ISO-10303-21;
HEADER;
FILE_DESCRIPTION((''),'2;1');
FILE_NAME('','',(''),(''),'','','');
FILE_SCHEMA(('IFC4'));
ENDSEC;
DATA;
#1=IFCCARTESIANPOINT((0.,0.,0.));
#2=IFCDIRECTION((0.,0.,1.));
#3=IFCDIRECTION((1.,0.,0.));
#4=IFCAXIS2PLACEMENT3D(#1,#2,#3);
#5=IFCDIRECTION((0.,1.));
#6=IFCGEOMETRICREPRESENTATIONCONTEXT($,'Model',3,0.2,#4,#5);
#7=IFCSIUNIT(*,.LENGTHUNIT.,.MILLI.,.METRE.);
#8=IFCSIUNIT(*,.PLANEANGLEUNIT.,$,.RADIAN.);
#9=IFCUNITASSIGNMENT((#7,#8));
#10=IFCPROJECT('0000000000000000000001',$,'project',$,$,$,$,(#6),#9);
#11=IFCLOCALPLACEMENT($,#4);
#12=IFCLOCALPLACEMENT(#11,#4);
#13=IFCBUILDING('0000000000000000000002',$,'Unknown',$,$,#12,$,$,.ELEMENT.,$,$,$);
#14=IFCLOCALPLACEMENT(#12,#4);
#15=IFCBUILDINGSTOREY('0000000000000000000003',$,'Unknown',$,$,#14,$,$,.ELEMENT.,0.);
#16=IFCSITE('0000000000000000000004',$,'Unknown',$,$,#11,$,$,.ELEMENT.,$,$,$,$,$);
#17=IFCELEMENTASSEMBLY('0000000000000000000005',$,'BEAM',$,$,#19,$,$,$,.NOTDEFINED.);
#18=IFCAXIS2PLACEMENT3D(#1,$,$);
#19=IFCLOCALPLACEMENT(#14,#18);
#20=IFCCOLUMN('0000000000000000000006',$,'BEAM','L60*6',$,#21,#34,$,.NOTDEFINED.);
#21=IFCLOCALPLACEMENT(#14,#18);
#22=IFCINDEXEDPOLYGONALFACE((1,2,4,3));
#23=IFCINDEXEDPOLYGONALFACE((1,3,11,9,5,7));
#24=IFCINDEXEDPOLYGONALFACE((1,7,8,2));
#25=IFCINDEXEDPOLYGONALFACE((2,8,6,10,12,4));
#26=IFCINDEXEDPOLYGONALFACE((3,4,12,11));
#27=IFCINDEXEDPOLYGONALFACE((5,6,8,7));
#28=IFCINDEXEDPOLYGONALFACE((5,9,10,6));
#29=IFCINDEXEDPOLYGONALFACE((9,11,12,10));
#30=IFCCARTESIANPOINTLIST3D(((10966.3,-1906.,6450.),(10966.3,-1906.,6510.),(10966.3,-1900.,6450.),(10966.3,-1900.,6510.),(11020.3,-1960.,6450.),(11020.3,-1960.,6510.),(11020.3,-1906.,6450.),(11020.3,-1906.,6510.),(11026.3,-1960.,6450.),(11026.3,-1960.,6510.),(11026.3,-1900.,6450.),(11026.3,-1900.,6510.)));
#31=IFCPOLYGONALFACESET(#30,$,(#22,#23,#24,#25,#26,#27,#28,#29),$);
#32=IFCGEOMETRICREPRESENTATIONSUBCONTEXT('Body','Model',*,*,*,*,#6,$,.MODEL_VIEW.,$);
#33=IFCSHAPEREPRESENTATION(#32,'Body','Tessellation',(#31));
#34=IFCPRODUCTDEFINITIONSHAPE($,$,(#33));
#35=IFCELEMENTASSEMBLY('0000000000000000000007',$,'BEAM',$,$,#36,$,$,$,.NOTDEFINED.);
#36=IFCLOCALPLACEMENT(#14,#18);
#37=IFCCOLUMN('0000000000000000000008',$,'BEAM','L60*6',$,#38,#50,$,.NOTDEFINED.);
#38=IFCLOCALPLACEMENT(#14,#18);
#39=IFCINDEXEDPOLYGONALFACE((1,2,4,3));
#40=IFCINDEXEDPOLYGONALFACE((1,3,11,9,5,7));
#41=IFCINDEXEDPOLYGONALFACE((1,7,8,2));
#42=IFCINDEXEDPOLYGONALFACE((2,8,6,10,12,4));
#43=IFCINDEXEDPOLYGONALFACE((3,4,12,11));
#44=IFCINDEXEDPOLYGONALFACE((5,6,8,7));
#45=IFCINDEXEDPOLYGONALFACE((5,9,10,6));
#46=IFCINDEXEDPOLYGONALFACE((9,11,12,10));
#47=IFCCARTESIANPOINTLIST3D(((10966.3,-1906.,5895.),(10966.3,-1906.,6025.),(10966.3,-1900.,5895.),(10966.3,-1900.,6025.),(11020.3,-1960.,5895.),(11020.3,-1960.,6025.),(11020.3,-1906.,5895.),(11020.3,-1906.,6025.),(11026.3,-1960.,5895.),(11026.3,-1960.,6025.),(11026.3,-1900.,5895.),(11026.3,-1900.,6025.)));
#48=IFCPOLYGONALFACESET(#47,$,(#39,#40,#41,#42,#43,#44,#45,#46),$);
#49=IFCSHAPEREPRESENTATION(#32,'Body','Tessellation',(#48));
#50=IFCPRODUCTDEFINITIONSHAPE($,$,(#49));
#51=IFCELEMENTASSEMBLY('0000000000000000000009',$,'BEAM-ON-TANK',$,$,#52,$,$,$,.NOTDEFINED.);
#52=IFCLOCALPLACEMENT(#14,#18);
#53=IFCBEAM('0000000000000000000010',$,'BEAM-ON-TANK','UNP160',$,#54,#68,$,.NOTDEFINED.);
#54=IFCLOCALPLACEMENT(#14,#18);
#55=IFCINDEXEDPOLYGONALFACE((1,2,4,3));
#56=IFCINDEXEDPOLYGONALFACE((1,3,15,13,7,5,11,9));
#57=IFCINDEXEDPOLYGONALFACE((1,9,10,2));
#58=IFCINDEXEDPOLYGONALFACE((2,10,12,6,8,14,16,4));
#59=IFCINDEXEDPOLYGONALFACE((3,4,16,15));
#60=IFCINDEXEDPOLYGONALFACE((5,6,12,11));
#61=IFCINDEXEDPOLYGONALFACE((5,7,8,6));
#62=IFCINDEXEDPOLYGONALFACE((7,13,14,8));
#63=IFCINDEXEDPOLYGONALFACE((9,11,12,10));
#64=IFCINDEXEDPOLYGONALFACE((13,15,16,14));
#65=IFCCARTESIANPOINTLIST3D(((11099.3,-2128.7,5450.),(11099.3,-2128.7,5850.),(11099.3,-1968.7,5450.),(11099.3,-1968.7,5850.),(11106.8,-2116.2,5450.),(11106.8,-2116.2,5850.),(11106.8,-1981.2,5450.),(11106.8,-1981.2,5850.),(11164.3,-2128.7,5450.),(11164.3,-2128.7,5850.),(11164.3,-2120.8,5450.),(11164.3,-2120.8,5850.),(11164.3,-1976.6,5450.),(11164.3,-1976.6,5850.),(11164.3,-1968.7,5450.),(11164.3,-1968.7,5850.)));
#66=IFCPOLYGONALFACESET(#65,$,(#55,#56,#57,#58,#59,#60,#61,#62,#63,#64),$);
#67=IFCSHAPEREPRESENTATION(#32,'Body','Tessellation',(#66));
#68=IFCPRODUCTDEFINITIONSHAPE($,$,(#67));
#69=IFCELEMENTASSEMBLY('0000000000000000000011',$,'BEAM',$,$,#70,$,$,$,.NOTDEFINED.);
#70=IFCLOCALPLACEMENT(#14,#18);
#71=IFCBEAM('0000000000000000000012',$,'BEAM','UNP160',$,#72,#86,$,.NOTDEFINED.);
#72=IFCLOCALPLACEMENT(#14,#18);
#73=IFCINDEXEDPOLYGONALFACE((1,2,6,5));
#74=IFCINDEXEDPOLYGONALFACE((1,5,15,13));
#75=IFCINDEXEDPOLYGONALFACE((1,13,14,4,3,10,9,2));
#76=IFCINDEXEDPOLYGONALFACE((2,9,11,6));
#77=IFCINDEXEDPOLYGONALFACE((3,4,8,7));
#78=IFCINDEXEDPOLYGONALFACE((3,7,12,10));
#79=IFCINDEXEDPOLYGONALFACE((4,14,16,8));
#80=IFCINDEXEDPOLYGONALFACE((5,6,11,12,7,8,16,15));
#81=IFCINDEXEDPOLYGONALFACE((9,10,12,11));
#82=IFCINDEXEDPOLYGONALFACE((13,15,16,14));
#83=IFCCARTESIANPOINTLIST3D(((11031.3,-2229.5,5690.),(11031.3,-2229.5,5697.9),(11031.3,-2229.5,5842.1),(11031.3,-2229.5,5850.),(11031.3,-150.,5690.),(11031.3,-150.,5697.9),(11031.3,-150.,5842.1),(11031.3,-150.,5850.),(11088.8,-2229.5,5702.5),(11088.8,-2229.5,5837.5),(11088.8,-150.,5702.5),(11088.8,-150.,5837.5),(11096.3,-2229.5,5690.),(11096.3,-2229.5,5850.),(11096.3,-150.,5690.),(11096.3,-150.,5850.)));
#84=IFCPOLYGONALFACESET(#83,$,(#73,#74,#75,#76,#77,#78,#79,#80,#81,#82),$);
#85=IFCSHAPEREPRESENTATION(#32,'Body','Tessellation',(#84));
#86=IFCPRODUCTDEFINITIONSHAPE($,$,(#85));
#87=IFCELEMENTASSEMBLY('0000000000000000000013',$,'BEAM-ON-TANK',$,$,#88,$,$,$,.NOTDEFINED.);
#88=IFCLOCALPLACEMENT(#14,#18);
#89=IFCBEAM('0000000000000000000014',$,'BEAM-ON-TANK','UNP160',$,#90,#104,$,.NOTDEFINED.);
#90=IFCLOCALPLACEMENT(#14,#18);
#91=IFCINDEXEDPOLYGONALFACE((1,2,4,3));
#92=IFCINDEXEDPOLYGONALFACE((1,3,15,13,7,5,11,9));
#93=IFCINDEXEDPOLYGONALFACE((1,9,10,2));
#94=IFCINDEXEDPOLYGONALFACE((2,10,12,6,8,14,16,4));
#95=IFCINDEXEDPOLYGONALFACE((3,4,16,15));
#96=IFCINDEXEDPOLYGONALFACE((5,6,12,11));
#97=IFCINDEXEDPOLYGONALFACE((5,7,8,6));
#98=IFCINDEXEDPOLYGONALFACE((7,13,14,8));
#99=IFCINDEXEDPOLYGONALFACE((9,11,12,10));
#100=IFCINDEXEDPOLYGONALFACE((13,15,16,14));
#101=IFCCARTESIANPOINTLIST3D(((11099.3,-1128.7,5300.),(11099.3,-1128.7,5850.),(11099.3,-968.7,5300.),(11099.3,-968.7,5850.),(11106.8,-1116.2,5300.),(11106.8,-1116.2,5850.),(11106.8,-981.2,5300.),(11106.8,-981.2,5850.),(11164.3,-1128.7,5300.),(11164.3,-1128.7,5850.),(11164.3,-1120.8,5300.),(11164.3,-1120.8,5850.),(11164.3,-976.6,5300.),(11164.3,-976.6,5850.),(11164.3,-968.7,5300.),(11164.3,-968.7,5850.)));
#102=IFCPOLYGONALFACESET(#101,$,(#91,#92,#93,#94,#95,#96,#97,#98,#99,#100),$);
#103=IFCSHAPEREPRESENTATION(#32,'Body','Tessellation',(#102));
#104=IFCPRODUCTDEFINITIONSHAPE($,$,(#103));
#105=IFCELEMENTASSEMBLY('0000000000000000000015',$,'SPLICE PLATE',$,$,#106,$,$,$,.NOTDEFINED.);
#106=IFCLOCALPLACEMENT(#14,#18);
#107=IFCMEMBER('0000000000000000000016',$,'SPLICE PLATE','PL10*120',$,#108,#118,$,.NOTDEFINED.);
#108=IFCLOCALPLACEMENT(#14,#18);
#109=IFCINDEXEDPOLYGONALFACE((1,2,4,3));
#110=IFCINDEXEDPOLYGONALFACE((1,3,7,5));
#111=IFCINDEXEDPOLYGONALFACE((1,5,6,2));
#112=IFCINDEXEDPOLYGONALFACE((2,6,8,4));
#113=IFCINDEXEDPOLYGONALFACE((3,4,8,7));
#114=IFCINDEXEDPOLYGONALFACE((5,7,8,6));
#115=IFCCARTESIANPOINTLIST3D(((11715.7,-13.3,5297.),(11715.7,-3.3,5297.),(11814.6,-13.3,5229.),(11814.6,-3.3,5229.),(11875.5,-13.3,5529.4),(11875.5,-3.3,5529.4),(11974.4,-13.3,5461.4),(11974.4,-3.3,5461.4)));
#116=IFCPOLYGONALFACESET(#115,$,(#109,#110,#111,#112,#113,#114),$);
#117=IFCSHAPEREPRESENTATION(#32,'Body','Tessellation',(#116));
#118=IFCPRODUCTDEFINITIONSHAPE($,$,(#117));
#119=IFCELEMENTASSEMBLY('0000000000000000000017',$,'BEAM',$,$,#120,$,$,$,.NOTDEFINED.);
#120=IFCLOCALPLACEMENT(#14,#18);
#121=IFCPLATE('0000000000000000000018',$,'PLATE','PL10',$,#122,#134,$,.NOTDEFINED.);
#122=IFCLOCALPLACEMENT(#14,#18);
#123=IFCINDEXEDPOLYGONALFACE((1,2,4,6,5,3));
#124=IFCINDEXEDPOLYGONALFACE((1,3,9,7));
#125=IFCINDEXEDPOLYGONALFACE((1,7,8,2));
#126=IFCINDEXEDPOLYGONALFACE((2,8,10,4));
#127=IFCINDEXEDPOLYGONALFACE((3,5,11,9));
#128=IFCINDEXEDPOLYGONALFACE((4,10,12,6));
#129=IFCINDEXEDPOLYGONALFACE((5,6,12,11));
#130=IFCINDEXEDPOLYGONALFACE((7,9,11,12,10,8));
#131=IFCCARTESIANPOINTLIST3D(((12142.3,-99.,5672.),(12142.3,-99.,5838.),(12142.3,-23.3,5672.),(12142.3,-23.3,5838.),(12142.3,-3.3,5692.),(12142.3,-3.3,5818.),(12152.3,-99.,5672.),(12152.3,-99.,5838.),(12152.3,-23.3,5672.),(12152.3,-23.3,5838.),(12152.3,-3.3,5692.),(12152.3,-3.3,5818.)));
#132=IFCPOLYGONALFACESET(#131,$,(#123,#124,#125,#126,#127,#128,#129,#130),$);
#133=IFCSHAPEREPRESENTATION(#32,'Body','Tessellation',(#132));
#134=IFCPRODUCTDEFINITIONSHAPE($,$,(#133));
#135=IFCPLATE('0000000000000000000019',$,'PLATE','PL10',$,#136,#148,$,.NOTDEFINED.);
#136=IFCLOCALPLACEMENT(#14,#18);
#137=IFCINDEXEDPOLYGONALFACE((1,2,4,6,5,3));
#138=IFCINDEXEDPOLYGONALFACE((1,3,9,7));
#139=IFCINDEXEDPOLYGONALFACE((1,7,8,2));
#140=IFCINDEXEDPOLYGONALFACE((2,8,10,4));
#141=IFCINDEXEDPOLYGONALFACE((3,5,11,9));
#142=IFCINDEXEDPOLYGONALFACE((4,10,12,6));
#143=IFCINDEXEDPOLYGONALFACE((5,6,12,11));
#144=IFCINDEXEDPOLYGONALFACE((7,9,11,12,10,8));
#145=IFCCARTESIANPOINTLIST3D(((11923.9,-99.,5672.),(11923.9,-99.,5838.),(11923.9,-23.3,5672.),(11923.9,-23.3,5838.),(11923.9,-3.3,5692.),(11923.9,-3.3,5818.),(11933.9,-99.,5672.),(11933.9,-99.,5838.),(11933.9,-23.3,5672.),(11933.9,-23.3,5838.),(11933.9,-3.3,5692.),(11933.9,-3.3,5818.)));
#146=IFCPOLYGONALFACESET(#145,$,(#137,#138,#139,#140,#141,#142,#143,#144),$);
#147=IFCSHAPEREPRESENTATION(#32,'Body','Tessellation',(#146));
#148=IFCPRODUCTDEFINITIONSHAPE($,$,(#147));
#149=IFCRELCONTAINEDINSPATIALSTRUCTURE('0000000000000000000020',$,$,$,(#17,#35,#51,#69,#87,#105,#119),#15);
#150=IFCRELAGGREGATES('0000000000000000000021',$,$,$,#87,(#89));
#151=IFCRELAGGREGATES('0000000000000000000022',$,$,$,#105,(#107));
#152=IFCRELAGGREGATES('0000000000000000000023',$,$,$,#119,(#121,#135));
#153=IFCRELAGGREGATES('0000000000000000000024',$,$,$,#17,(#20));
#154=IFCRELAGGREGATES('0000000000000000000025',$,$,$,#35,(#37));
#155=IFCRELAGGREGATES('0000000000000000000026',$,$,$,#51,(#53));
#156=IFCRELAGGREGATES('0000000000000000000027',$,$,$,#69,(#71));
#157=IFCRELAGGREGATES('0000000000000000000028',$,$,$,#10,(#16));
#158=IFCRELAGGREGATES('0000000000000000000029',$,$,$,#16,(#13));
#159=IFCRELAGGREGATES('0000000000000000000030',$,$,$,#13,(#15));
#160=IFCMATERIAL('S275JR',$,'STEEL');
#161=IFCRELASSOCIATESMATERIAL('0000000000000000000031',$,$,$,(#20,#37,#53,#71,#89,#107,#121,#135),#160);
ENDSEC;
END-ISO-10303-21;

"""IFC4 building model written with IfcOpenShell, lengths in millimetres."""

from ifc_helpers import new_model, si_unit, direction, frame, origin_with_axes, place, context, subcontext, project, spatial, line, indexed_curve, outline, extrude, material, element, aggregate, save


model = new_model("IFC4")

# Units and contexts
model_context = context("Model", 3, precision=0.2, world=origin_with_axes(), true_north=direction((0.0, 1.0)))
body_context = subcontext(model_context, "Body", "Model", "MODEL_VIEW")
ifc_project = project(units=[si_unit("LENGTHUNIT", "METRE", prefix="MILLI"), si_unit("PLANEANGLEUNIT", "RADIAN")], contexts=[model_context])

# Site, building, storey
site_placement = place(None, origin_with_axes())
site = spatial("IfcSite", under=ifc_project, at=site_placement, Name="Unknown", CompositionType="ELEMENT")
building_placement = place(site_placement, origin_with_axes())
building = spatial("IfcBuilding", under=site, at=building_placement, Name="Unknown", CompositionType="ELEMENT")
storey_placement = place(building_placement, origin_with_axes())
storey = spatial("IfcBuildingStorey", under=building, at=storey_placement, Name="Unknown", CompositionType="ELEMENT", Elevation=0.0)

# Element assemblies, columns
assembly_1_placement = place(storey_placement, frame((10996.3, -1930.0, 6450.0), z_axis=(0.0, -1.0, 0.000002), x_axis=(0.0, 0.0, 1.0)))
assembly_1 = element("IfcElementAssembly", 1, at=assembly_1_placement, inside=storey, Name="BEAM", PredefinedType="NOTDEFINED")
ifc_material_1 = material(Name="S275JR", Category="STEEL")
column_1_placement = place(assembly_1_placement, origin_with_axes())
column_1 = element("IfcColumn", 2, at=column_1_placement, material=ifc_material_1, Name="BEAM", Description="L60*6", PredefinedType="NOTDEFINED", context=body_context, shape_type="SolidModel", body=[
    extrude(outline(indexed_curve([(-30.0, -30.0), (30.0, -30.0), (30.0, -24.0), (-24.0, -24.0), (-24.0, 30.0), (-30.0, 30.0)], segments=[line(1, 2, 3, 4, 5, 6, 1)])), frame((0.0, 0.0, 0.0), z_axis=(-1.0, 0.0, 0.0), x_axis=(0.0, 0.0, 1.0)), (0.0, -0.000002, -1.0), 60.0),
])
assembly_2_placement = place(storey_placement, frame((10996.3, -1930.0, 5895.0), z_axis=(0.0, -1.0, 0.000002), x_axis=(0.0, 0.0, 1.0)))
assembly_2 = element("IfcElementAssembly", 3, at=assembly_2_placement, inside=storey, Name="BEAM", PredefinedType="NOTDEFINED")
column_2_placement = place(assembly_2_placement, origin_with_axes())
column_2 = element("IfcColumn", 4, at=column_2_placement, material=ifc_material_1, Name="BEAM", Description="L60*6", PredefinedType="NOTDEFINED", context=body_context, shape_type="SolidModel", body=[
    extrude(outline(indexed_curve([(-30.0, -30.0), (30.0, -30.0), (30.0, -24.0), (-24.0, -24.0), (-24.0, 30.0), (-30.0, 30.0)], segments=[line(1, 2, 3, 4, 5, 6, 1)])), frame((0.0, 0.0, 0.0), z_axis=(-1.0, 0.0, 0.0), x_axis=(0.0, 0.0, 1.0)), (0.0, -0.000002, -1.0), 130.0),
])

# Element assemblies, beams
assembly_3_placement = place(storey_placement, frame((11131.8, -2048.7, 5850.0), z_axis=(1.0, 0.0, 0.0), x_axis=(0.0, -0.000002, -1.0)))
assembly_3 = element("IfcElementAssembly", 5, at=assembly_3_placement, inside=storey, Name="BEAM-ON-TANK", PredefinedType="NOTDEFINED")
beam_1_placement = place(assembly_3_placement, origin_with_axes())
beam_1 = element("IfcBeam", 6, at=beam_1_placement, material=ifc_material_1, Name="BEAM-ON-TANK", Description="UNP160", PredefinedType="NOTDEFINED", context=body_context, shape_type="SolidModel", body=[
    extrude(outline(indexed_curve([(-32.5, -80.0), (32.5, -80.0), (32.5, -72.1), (-25.0, -67.5), (-25.0, 67.5), (32.5, 72.1), (32.5, 80.0), (-32.5, 80.0)], segments=[line(1, 2, 3, 4, 5, 6, 7, 8, 1)])), frame((0.0, 0.0, 0.0), z_axis=(-1.0, 0.0, 0.0), x_axis=(0.0, 0.0, 1.0)), (0.0, -0.000002, -1.0), 400.0),
])
assembly_4_placement = place(storey_placement, frame((11031.3, -2197.0, 5770.0), z_axis=(0.0, -1.0, 0.000002), x_axis=(1.0, 0.0, 0.0)))
assembly_4 = element("IfcElementAssembly", 7, at=assembly_4_placement, inside=storey, Name="BEAM", PredefinedType="NOTDEFINED")
beam_2_placement = place(assembly_4_placement, frame((32.5, 0.0, -2047.0), z_axis=(-1.0, 0.0, -0.000011), x_axis=(0.0, 0.0, 1.0)))
beam_2 = element("IfcBeam", 8, at=beam_2_placement, material=ifc_material_1, Name="BEAM", Description="UNP160", PredefinedType="NOTDEFINED", context=body_context, shape_type="SolidModel", body=[
    extrude(outline(indexed_curve([(-32.5, -80.0), (32.5, -80.0), (32.5, -72.1), (-25.0, -67.5), (-25.0, 67.5), (32.5, 72.1), (32.5, 80.0), (-32.5, 80.0)], segments=[line(1, 2, 3, 4, 5, 6, 7, 8, 1)])), frame((0.0, 0.0, 0.0), z_axis=(-1.0, 0.0, 0.0), x_axis=(0.0, 0.0, 1.0)), (0.0, -0.000002, -1.0), 2079.5),
])
assembly_5_placement = place(storey_placement, frame((11131.8, -1048.7, 5850.0), z_axis=(1.0, 0.0, 0.0), x_axis=(0.0, -0.000002, -1.0)))
assembly_5 = element("IfcElementAssembly", 9, at=assembly_5_placement, inside=storey, Name="BEAM-ON-TANK", PredefinedType="NOTDEFINED")
beam_3_placement = place(assembly_5_placement, origin_with_axes())
beam_3 = element("IfcBeam", 10, at=beam_3_placement, material=ifc_material_1, Name="BEAM-ON-TANK", Description="UNP160", PredefinedType="NOTDEFINED", context=body_context, shape_type="SolidModel", body=[
    extrude(outline(indexed_curve([(-32.5, -80.0), (32.5, -80.0), (32.5, -72.1), (-25.0, -67.5), (-25.0, 67.5), (32.5, 72.1), (32.5, 80.0), (-32.5, 80.0)], segments=[line(1, 2, 3, 4, 5, 6, 7, 8, 1)])), frame((0.0, 0.0, 0.0), z_axis=(-1.0, 0.0, 0.0), x_axis=(0.0, 0.0, 1.0)), (0.0, -0.000002, -1.0), 550.0),
])
aggregate(assembly_5, [beam_3])

# Element assembly, member
assembly_6_placement = place(storey_placement, frame((11924.9, -8.3, 5495.4), z_axis=(0.0, 1.0, 0.0), x_axis=(-0.566581, 0.0, -0.824006)))
assembly_6 = element("IfcElementAssembly", 11, at=assembly_6_placement, inside=storey, Name="SPLICE PLATE", PredefinedType="NOTDEFINED")
member_placement = place(assembly_6_placement, origin_with_axes())
member = element("IfcMember", 12, at=member_placement, material=ifc_material_1, Name="SPLICE PLATE", Description="PL10*120", PredefinedType="NOTDEFINED", context=body_context, shape_type="SolidModel", body=[
    extrude(outline(indexed_curve([(-5.0, -60.0), (5.0, -60.0), (5.0, 60.0), (-5.0, 60.0)], segments=[line(1, 2, 3, 4, 1)])), frame((0.0, 0.0, 0.0), z_axis=(-1.0, 0.0, 0.0), x_axis=(0.0, 0.0, 1.0)), (0.0, -0.000002, -1.0), 282.0),
])
aggregate(assembly_6, [member])

# Element assembly, plates
assembly_7_placement = place(storey_placement, frame((14600.0, 0.0, 5755.0), z_axis=(0.0, 1.0, 0.0), x_axis=(-1.0, 0.0, 0.0)))
assembly_7 = element("IfcElementAssembly", 13, at=assembly_7_placement, inside=storey, Name="BEAM", PredefinedType="NOTDEFINED")
plate_1_placement = place(assembly_7_placement, frame((2452.7, -83.0, -99.0), z_axis=(-1.0, 0.0, 0.0), x_axis=(0.0, 0.0, 1.0)))
plate_1 = element("IfcPlate", 14, at=plate_1_placement, material=ifc_material_1, Name="PLATE", Description="PL10", PredefinedType="NOTDEFINED", context=body_context, shape_type="SolidModel", body=[
    extrude(outline(indexed_curve([(0.0, 0.0), (75.8, 0.0), (95.8, 20.0), (95.8, 146.0), (75.8, 166.0), (0.0, 166.0)], segments=[line(1, 2, 3, 4, 5, 6, 1)])), frame((0.0, 0.0, 5.0), z_axis=(0.0, 0.0, 1.0), x_axis=(1.0, 0.0, 0.0)), (0.0, -0.000002, -1.0), 10.0),
])
plate_2_placement = place(assembly_7_placement, frame((2671.1, -83.0, -99.0), z_axis=(-1.0, 0.0, 0.0), x_axis=(0.0, 0.0, 1.0)))
plate_2 = element("IfcPlate", 15, at=plate_2_placement, material=ifc_material_1, Name="PLATE", Description="PL10", PredefinedType="NOTDEFINED", context=body_context, shape_type="SolidModel", body=[
    extrude(outline(indexed_curve([(0.0, 0.0), (75.8, 0.0), (95.8, 20.0), (95.8, 146.0), (75.8, 166.0), (0.0, 166.0)], segments=[line(1, 2, 3, 4, 5, 6, 1)])), frame((0.0, 0.0, 5.0), z_axis=(0.0, 0.0, 1.0), x_axis=(1.0, 0.0, 0.0)), (0.0, -0.000002, -1.0), 10.0),
])
aggregate(assembly_7, [plate_1, plate_2])

aggregate(assembly_1, [column_1])
aggregate(assembly_2, [column_2])

aggregate(assembly_3, [beam_1])
aggregate(assembly_4, [beam_2])

save(model, "model.ifc")
